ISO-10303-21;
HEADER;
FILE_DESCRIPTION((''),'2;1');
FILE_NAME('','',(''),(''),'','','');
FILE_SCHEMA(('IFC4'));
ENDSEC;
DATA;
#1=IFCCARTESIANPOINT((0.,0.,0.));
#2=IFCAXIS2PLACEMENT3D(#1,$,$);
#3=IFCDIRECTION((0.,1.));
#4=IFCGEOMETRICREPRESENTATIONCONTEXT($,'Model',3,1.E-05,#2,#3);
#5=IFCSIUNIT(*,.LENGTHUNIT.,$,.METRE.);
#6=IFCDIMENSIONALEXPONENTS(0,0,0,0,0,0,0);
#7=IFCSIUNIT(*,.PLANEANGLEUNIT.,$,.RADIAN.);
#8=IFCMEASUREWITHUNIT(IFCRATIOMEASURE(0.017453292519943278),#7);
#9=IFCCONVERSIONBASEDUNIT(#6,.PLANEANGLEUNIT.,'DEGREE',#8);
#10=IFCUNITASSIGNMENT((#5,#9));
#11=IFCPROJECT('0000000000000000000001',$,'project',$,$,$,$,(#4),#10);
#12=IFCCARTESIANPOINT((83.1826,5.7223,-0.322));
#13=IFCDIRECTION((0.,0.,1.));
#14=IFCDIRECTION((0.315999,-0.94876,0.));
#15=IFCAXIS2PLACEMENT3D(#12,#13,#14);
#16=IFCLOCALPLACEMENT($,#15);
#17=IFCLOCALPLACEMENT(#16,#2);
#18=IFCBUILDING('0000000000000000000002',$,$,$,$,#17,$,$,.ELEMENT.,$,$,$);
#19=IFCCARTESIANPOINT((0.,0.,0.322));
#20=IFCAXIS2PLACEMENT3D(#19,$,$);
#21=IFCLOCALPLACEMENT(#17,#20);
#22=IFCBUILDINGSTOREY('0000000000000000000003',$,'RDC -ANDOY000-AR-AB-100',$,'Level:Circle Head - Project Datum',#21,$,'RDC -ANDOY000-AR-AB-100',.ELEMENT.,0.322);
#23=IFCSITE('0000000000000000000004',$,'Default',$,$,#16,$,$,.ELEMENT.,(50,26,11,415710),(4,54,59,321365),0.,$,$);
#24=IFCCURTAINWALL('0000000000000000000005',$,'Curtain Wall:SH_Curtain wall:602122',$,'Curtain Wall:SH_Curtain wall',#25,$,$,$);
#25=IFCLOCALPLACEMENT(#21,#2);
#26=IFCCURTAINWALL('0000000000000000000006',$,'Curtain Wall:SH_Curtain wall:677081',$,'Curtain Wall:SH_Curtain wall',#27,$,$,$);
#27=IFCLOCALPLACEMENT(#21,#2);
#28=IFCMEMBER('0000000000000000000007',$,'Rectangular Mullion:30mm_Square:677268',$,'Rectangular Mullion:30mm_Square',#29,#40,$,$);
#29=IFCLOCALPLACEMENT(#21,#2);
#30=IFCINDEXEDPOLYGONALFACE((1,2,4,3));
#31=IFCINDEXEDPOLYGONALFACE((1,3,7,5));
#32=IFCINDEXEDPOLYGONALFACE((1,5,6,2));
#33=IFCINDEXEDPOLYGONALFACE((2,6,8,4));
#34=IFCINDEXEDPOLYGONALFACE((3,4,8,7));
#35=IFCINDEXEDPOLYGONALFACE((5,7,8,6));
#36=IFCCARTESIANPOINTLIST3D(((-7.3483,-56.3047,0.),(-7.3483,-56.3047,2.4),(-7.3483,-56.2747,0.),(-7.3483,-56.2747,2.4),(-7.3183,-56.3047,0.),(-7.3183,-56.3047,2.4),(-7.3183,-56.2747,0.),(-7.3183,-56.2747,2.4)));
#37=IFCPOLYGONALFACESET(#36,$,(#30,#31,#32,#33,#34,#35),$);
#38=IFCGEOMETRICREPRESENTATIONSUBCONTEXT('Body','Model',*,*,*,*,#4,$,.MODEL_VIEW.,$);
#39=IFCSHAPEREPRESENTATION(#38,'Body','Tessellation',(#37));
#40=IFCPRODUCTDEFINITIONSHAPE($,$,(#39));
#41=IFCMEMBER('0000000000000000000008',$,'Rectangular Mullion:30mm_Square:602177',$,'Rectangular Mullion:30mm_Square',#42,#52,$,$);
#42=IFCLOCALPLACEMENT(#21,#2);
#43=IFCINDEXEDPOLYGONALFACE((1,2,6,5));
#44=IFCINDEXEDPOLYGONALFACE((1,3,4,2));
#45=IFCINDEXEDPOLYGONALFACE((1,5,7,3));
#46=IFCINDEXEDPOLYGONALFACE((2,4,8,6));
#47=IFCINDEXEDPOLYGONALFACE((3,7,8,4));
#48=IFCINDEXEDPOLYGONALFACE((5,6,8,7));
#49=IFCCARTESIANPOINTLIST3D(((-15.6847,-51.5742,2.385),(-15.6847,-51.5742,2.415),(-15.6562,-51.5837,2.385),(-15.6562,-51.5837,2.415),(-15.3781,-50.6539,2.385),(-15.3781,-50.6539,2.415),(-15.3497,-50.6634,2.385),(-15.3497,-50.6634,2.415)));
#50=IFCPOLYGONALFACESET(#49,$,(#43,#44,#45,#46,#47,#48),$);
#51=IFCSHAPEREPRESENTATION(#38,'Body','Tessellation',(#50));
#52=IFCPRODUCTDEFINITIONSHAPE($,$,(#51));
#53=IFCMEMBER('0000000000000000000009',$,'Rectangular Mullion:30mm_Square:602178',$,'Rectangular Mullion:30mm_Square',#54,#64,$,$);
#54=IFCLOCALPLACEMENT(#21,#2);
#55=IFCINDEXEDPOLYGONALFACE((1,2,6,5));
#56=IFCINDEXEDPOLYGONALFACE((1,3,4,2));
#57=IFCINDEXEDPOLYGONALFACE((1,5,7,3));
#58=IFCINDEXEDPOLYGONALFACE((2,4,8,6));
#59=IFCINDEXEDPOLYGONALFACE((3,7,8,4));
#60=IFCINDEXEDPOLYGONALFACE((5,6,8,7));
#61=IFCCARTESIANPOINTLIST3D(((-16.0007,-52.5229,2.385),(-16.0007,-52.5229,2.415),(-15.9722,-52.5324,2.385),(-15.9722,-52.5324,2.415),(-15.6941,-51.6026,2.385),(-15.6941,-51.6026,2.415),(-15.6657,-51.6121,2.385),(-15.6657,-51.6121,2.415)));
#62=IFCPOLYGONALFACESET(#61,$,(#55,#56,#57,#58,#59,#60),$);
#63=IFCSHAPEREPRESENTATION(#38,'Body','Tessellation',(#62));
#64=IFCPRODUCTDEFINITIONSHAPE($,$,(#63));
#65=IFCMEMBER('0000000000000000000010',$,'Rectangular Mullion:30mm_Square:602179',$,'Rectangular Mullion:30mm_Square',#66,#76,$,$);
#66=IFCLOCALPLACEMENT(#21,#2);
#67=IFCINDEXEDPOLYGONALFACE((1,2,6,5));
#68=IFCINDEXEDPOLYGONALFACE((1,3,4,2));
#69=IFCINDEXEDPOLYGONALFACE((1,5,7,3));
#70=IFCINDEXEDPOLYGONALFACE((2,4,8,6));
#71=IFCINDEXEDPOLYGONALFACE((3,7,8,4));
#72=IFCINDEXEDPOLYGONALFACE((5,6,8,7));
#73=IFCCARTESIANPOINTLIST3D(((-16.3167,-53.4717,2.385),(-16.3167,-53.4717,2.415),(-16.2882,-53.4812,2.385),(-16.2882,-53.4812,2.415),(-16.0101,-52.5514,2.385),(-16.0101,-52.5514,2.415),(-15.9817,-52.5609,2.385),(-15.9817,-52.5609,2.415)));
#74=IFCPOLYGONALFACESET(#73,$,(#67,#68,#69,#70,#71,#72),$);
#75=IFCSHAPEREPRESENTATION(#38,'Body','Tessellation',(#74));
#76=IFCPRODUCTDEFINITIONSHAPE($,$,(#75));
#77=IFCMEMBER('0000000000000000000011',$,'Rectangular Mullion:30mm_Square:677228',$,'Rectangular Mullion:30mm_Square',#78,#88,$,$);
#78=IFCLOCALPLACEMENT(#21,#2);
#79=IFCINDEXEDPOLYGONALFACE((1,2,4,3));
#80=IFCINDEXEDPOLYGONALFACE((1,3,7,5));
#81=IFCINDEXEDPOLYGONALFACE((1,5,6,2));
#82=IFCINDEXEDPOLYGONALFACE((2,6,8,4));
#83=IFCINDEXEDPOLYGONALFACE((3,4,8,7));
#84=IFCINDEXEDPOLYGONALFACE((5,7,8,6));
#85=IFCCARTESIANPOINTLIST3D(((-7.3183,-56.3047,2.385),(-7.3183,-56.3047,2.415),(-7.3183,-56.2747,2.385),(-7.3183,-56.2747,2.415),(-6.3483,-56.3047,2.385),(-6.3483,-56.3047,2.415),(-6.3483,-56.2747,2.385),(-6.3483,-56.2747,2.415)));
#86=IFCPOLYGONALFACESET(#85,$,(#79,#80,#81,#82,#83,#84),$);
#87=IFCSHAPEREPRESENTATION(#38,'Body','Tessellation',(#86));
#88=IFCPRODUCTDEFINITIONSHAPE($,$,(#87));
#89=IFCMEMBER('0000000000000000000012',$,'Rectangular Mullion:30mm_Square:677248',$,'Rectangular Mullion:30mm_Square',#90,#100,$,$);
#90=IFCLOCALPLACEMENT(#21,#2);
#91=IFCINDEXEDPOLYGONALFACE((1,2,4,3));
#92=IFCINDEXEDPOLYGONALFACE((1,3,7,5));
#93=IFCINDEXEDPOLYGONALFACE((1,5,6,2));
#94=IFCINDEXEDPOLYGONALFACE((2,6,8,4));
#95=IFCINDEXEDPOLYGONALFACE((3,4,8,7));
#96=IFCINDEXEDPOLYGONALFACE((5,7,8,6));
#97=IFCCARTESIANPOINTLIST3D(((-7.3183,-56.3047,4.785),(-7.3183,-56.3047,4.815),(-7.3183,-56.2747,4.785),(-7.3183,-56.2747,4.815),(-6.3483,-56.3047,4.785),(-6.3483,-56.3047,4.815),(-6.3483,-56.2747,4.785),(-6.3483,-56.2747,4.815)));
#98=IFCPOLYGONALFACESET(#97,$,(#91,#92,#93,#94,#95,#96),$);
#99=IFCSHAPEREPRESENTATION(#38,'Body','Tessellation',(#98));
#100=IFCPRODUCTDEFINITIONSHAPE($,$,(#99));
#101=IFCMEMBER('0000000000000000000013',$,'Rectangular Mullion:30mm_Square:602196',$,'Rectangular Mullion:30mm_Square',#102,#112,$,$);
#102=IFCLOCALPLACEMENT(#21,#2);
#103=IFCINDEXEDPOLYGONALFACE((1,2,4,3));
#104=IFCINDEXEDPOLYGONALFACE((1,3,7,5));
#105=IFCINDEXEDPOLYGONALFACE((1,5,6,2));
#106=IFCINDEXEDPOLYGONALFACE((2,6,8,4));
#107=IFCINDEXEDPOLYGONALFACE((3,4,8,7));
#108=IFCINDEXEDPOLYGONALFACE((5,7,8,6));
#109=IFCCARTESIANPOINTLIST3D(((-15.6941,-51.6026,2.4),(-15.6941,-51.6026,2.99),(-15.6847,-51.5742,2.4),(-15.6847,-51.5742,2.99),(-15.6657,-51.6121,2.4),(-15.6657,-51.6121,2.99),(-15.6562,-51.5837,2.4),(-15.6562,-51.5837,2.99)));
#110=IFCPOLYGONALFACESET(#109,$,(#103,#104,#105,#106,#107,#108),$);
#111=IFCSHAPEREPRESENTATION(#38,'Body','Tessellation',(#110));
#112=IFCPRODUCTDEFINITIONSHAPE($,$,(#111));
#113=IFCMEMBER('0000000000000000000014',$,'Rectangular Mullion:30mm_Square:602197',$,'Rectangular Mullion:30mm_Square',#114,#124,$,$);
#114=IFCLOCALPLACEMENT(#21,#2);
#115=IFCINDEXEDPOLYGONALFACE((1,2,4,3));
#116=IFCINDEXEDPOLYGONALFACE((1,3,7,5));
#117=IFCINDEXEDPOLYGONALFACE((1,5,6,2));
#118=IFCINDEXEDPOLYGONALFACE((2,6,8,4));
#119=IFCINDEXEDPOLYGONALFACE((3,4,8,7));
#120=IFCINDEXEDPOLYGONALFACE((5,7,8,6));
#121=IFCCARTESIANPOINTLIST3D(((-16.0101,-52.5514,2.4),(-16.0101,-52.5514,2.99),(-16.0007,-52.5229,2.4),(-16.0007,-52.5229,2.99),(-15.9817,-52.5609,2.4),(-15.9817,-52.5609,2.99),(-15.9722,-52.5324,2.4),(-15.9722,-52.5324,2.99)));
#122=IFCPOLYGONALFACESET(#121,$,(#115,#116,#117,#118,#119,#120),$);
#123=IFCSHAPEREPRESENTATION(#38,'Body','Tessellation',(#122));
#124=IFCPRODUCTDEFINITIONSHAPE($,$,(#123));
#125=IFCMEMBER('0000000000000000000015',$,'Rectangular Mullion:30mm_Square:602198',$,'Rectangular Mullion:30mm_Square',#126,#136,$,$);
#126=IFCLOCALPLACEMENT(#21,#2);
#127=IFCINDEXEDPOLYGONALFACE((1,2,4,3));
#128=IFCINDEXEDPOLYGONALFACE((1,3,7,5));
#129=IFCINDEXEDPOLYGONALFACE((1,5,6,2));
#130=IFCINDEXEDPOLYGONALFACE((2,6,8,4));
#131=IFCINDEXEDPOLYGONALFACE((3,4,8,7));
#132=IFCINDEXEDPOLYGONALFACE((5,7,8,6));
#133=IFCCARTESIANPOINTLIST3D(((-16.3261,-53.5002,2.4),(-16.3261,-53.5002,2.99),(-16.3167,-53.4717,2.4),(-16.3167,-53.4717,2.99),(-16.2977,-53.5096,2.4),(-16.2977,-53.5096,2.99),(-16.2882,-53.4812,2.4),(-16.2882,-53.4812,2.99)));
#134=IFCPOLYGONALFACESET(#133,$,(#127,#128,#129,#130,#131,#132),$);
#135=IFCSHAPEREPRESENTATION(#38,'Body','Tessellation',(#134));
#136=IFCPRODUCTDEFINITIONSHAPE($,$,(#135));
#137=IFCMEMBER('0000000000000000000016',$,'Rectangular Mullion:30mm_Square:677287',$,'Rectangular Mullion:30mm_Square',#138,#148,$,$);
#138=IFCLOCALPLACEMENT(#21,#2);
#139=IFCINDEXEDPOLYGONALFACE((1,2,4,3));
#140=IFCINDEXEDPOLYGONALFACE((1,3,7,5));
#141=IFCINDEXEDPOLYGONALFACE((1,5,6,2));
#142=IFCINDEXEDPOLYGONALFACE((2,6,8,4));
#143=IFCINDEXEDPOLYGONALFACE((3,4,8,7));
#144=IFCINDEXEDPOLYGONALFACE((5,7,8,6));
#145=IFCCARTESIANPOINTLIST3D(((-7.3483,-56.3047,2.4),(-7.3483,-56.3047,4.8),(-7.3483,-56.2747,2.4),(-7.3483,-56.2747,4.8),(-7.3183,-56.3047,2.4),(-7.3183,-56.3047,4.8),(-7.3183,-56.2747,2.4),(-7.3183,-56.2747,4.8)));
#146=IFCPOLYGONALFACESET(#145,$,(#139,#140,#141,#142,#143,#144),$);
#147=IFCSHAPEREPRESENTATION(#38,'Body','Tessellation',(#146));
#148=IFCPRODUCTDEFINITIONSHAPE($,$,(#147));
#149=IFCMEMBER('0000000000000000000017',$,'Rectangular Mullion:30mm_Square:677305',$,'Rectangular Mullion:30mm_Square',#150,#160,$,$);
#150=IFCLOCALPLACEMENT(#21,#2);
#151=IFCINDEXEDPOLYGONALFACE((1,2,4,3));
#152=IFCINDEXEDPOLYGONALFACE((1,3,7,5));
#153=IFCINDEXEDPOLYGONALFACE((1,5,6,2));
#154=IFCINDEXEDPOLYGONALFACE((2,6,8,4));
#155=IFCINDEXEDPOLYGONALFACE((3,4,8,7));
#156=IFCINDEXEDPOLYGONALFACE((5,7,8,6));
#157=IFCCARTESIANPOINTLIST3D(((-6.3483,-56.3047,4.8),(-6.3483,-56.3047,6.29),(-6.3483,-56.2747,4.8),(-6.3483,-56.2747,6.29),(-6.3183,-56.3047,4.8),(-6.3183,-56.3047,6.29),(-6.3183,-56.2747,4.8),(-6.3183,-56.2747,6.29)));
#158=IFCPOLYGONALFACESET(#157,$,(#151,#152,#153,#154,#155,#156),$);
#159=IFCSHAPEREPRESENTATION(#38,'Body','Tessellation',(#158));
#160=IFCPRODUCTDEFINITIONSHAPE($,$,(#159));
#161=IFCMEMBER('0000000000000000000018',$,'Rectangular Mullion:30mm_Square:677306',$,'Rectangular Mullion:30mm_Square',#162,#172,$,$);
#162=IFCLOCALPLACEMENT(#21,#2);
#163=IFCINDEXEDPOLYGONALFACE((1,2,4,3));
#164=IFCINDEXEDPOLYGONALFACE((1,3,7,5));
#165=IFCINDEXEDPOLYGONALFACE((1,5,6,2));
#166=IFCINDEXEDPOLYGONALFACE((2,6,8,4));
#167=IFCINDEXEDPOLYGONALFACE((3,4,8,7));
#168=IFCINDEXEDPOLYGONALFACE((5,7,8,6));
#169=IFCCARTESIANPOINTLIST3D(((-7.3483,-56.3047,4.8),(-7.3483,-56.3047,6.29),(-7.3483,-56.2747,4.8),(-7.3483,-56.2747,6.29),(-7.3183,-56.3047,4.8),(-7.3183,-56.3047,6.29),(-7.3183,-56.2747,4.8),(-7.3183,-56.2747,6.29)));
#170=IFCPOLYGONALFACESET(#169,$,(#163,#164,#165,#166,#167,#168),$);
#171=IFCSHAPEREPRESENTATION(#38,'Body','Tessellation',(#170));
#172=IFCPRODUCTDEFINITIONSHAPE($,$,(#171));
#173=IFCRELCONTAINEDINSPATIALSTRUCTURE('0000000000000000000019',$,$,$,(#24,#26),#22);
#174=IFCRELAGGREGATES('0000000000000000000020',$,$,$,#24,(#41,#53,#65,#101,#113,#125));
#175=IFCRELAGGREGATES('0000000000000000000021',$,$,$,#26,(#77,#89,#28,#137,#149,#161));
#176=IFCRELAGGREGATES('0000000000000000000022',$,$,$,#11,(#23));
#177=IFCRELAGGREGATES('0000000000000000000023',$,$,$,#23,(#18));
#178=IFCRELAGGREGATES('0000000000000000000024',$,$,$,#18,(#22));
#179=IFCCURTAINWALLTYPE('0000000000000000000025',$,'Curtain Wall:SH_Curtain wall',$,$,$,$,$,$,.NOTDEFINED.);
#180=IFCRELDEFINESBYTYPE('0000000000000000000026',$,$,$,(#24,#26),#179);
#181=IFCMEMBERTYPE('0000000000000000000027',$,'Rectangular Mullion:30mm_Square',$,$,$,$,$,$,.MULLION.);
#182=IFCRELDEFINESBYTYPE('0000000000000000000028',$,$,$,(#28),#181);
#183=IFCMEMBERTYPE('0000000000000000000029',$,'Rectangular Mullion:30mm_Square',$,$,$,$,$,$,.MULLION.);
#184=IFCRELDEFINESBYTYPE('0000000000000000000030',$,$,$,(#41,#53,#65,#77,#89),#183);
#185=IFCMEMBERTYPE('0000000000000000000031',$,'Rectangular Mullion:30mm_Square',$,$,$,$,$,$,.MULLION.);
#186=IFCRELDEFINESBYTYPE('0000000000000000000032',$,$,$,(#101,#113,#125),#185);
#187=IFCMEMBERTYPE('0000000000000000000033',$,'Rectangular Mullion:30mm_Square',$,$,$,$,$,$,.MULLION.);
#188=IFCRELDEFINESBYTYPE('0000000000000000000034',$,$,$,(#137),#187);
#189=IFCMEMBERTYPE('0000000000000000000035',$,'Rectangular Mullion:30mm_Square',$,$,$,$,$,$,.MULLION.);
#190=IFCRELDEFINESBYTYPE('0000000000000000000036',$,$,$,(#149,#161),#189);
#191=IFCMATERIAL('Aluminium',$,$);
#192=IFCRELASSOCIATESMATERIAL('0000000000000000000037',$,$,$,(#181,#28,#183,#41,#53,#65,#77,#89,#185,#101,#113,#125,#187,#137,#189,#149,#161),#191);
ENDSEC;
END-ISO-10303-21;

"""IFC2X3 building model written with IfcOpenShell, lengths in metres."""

from ifc_helpers import new_model, entity, si_unit, converted_unit, direction, frame, origin, origin_2d_with_axis, place, context, subcontext, project, spatial, rectangle, extrude, source, transform, mapped, material, type_object, type_shapes, element, aggregate, save


model = new_model("IFC2X3")

# Units and contexts
model_context = context("Model", 3, precision=1e-05, world=origin(), true_north=direction((0.0, 1.0)))
body_context = subcontext(model_context, "Body", "Model", "MODEL_VIEW")
ifc_project = project(units=[si_unit("LENGTHUNIT", "METRE"), converted_unit("PLANEANGLEUNIT", "DEGREE", entity("IfcRatioMeasure", 0.017453292519943278), si_unit("PLANEANGLEUNIT", "RADIAN"), dimensions=[0, 0, 0, 0, 0, 0, 0])], contexts=[model_context])

# Site, building, storey
site_placement = place(None, frame((83.1826, 5.7223, -0.322), z_axis=(0.0, 0.0, 1.0), x_axis=(0.315999, -0.94876, 0.0)))
site = spatial("IfcSite", under=ifc_project, at=site_placement, Name="Default", CompositionType="ELEMENT", RefLatitude=(50, 26, 11, 415710), RefLongitude=(4, 54, 59, 321365), RefElevation=0.0)
building_placement = place(site_placement, origin())
building = spatial("IfcBuilding", under=site, at=building_placement, CompositionType="ELEMENT")
storey_placement = place(building_placement, frame((0.0, 0.0, 0.322)))
storey = spatial("IfcBuildingStorey", under=building, at=storey_placement, Name="RDC -ANDOY000-AR-AB-100", ObjectType="Level:Circle Head - Project Datum", LongName="RDC -ANDOY000-AR-AB-100", CompositionType="ELEMENT", Elevation=0.322)

# Curtain wall
curtain_wall_type = type_object("IfcCurtainWallType", Name="Curtain Wall:SH_Curtain wall", PredefinedType="NOTDEFINED")
curtain_wall_1_placement = place(storey_placement, frame((0.0, 0.0, -0.322)))
curtain_wall_1 = element("IfcCurtainWall", 1, at=curtain_wall_1_placement, inside=storey, type_object=curtain_wall_type, Name="Curtain Wall:SH_Curtain wall:602122", ObjectType="Curtain Wall:SH_Curtain wall")
ifc_material_1 = material(Name="Aluminium")

# Curtain wall
curtain_wall_2_placement = place(storey_placement, frame((0.0, 0.0, -0.322)))
curtain_wall_2 = element("IfcCurtainWall", 2, at=curtain_wall_2_placement, inside=storey, type_object=curtain_wall_type, Name="Curtain Wall:SH_Curtain wall:677081", ObjectType="Curtain Wall:SH_Curtain wall")

# Members
member_type_1 = type_object("IfcMemberType", Name="Rectangular Mullion:30mm_Square", PredefinedType="MULLION", material=ifc_material_1)
shared_shape_1 = source(origin(), body_context, "Body", "SweptSolid", [
    extrude(rectangle(XDim=0.03, YDim=0.03, at=origin_2d_with_axis()), frame((0.0, 0.0, -2.4), z_axis=(0.0, 0.0, 1.0), x_axis=(0.0, -1.0, 0.0)), (0.0, 0.0, 1.0), 2.4),
])
type_shapes(member_type_1, [shared_shape_1])
member_1_placement = place(curtain_wall_2_placement, frame((-7.3333, -56.2897, 0.322), z_axis=(0.0, 0.0, -1.0), x_axis=(-1.0, 0.0, 0.0)))
member_1 = element("IfcMember", 3, at=member_1_placement, type_object=member_type_1, material=ifc_material_1, Name="Rectangular Mullion:30mm_Square:677268", ObjectType="Rectangular Mullion:30mm_Square", context=body_context, shape_type="MappedRepresentation", body=[
    mapped(shared_shape_1, transform((0.0, 0.0, 0.0), scale=1.0)),
])
member_type_2 = type_object("IfcMemberType", Name="Rectangular Mullion:30mm_Square", PredefinedType="MULLION", material=ifc_material_1)
shared_shape_2 = source(origin(), body_context, "Body", "SweptSolid", [
    extrude(rectangle(XDim=0.03, YDim=0.03, at=origin_2d_with_axis()), frame((0.0, 0.0, -0.97), z_axis=(0.0, 0.0, 1.0), x_axis=(0.0, -1.0, 0.0)), (0.0, 0.0, 1.0), 0.97),
])
type_shapes(member_type_2, [shared_shape_2])
member_2_placement = place(curtain_wall_1_placement, frame((-15.6704, -51.5789, 2.722), z_axis=(-0.316, -0.948759, 0.0), x_axis=(0.0, 0.0, 1.0)))
member_2 = element("IfcMember", 4, at=member_2_placement, type_object=member_type_2, material=ifc_material_1, Name="Rectangular Mullion:30mm_Square:602177", ObjectType="Rectangular Mullion:30mm_Square", context=body_context, shape_type="MappedRepresentation", body=[
    mapped(shared_shape_2, transform((0.0, 0.0, 0.0), scale=1.0)),
])
member_3_placement = place(curtain_wall_1_placement, frame((-15.9864, -52.5277, 2.722), z_axis=(-0.316, -0.948759, 0.0), x_axis=(0.0, 0.0, 1.0)))
member_3 = element("IfcMember", 5, at=member_3_placement, type_object=member_type_2, material=ifc_material_1, Name="Rectangular Mullion:30mm_Square:602178", ObjectType="Rectangular Mullion:30mm_Square", context=body_context, shape_type="MappedRepresentation", body=[
    mapped(shared_shape_2, transform((0.0, 0.0, 0.0), scale=1.0)),
])
member_4_placement = place(curtain_wall_1_placement, frame((-16.3024, -53.4764, 2.722), z_axis=(-0.316, -0.948759, 0.0), x_axis=(0.0, 0.0, 1.0)))
member_4 = element("IfcMember", 6, at=member_4_placement, type_object=member_type_2, material=ifc_material_1, Name="Rectangular Mullion:30mm_Square:602179", ObjectType="Rectangular Mullion:30mm_Square", context=body_context, shape_type="MappedRepresentation", body=[
    mapped(shared_shape_2, transform((0.0, 0.0, 0.0), scale=1.0)),
])
member_5_placement = place(curtain_wall_2_placement, frame((-7.3183, -56.2897, 2.722), z_axis=(-1.0, 0.0, 0.0), x_axis=(0.0, 0.0, 1.0)))
member_5 = element("IfcMember", 7, at=member_5_placement, type_object=member_type_2, material=ifc_material_1, Name="Rectangular Mullion:30mm_Square:677228", ObjectType="Rectangular Mullion:30mm_Square", context=body_context, shape_type="MappedRepresentation", body=[
    mapped(shared_shape_2, transform((0.0, 0.0, 0.0), scale=1.0)),
])
member_6_placement = place(curtain_wall_2_placement, frame((-7.3183, -56.2897, 5.122), z_axis=(-1.0, 0.0, 0.0), x_axis=(0.0, 0.0, 1.0)))
member_6 = element("IfcMember", 8, at=member_6_placement, type_object=member_type_2, material=ifc_material_1, Name="Rectangular Mullion:30mm_Square:677248", ObjectType="Rectangular Mullion:30mm_Square", context=body_context, shape_type="MappedRepresentation", body=[
    mapped(shared_shape_2, transform((0.0, 0.0, 0.0), scale=1.0)),
])
member_type_3 = type_object("IfcMemberType", Name="Rectangular Mullion:30mm_Square", PredefinedType="MULLION", material=ifc_material_1)
shared_shape_3 = source(origin(), body_context, "Body", "SweptSolid", [
    extrude(rectangle(XDim=0.03, YDim=0.03, at=origin_2d_with_axis()), frame((0.0, 0.0, -0.59), z_axis=(0.0, 0.0, 1.0), x_axis=(0.0, -1.0, 0.0)), (0.0, 0.0, 1.0), 0.59),
])
type_shapes(member_type_3, [shared_shape_3])
member_7_placement = place(curtain_wall_1_placement, frame((-15.6752, -51.5932, 2.722), z_axis=(0.0, 0.0, -1.0), x_axis=(-0.316, -0.948759, 0.0)))
member_7 = element("IfcMember", 9, at=member_7_placement, type_object=member_type_3, material=ifc_material_1, Name="Rectangular Mullion:30mm_Square:602196", ObjectType="Rectangular Mullion:30mm_Square", context=body_context, shape_type="MappedRepresentation", body=[
    mapped(shared_shape_3, transform((0.0, 0.0, 0.0), scale=1.0)),
])
member_8_placement = place(curtain_wall_1_placement, frame((-15.9912, -52.5419, 2.722), z_axis=(0.0, 0.0, -1.0), x_axis=(-0.316, -0.948759, 0.0)))
member_8 = element("IfcMember", 10, at=member_8_placement, type_object=member_type_3, material=ifc_material_1, Name="Rectangular Mullion:30mm_Square:602197", ObjectType="Rectangular Mullion:30mm_Square", context=body_context, shape_type="MappedRepresentation", body=[
    mapped(shared_shape_3, transform((0.0, 0.0, 0.0), scale=1.0)),
])
member_9_placement = place(curtain_wall_1_placement, frame((-16.3072, -53.4907, 2.722), z_axis=(0.0, 0.0, -1.0), x_axis=(-0.316, -0.948759, 0.0)))
member_9 = element("IfcMember", 11, at=member_9_placement, type_object=member_type_3, material=ifc_material_1, Name="Rectangular Mullion:30mm_Square:602198", ObjectType="Rectangular Mullion:30mm_Square", context=body_context, shape_type="MappedRepresentation", body=[
    mapped(shared_shape_3, transform((0.0, 0.0, 0.0), scale=1.0)),
])
member_type_4 = type_object("IfcMemberType", Name="Rectangular Mullion:30mm_Square", PredefinedType="MULLION", material=ifc_material_1)
shared_shape_4 = source(origin(), body_context, "Body", "SweptSolid", [
    extrude(rectangle(XDim=0.03, YDim=0.03, at=origin_2d_with_axis()), frame((0.0, 0.0, -2.4), z_axis=(0.0, 0.0, 1.0), x_axis=(0.0, -1.0, 0.0)), (0.0, 0.0, 1.0), 2.4),
])
type_shapes(member_type_4, [shared_shape_4])
member_10_placement = place(curtain_wall_2_placement, frame((-7.3333, -56.2897, 2.722), z_axis=(0.0, 0.0, -1.0), x_axis=(-1.0, 0.0, 0.0)))
member_10 = element("IfcMember", 12, at=member_10_placement, type_object=member_type_4, material=ifc_material_1, Name="Rectangular Mullion:30mm_Square:677287", ObjectType="Rectangular Mullion:30mm_Square", context=body_context, shape_type="MappedRepresentation", body=[
    mapped(shared_shape_4, transform((0.0, 0.0, 0.0), scale=1.0)),
])
member_type_5 = type_object("IfcMemberType", Name="Rectangular Mullion:30mm_Square", PredefinedType="MULLION", material=ifc_material_1)
shared_shape_5 = source(origin(), body_context, "Body", "SweptSolid", [
    extrude(rectangle(XDim=0.03, YDim=0.03, at=origin_2d_with_axis()), frame((0.0, 0.0, -1.49), z_axis=(0.0, 0.0, 1.0), x_axis=(0.0, -1.0, 0.0)), (0.0, 0.0, 1.0), 1.49),
])
type_shapes(member_type_5, [shared_shape_5])
member_11_placement = place(curtain_wall_2_placement, frame((-6.3333, -56.2897, 5.122), z_axis=(0.0, 0.0, -1.0), x_axis=(-1.0, 0.0, 0.0)))
member_11 = element("IfcMember", 13, at=member_11_placement, type_object=member_type_5, material=ifc_material_1, Name="Rectangular Mullion:30mm_Square:677305", ObjectType="Rectangular Mullion:30mm_Square", context=body_context, shape_type="MappedRepresentation", body=[
    mapped(shared_shape_5, transform((0.0, 0.0, 0.0), scale=1.0)),
])
member_12_placement = place(curtain_wall_2_placement, frame((-7.3333, -56.2897, 5.122), z_axis=(0.0, 0.0, -1.0), x_axis=(-1.0, 0.0, 0.0)))
member_12 = element("IfcMember", 14, at=member_12_placement, type_object=member_type_5, material=ifc_material_1, Name="Rectangular Mullion:30mm_Square:677306", ObjectType="Rectangular Mullion:30mm_Square", context=body_context, shape_type="MappedRepresentation", body=[
    mapped(shared_shape_5, transform((0.0, 0.0, 0.0), scale=1.0)),
])

aggregate(curtain_wall_1, [member_2, member_3, member_4, member_7, member_8, member_9])
aggregate(curtain_wall_2, [member_5, member_6, member_1, member_10, member_11, member_12])

save(model, "model.ifc")
